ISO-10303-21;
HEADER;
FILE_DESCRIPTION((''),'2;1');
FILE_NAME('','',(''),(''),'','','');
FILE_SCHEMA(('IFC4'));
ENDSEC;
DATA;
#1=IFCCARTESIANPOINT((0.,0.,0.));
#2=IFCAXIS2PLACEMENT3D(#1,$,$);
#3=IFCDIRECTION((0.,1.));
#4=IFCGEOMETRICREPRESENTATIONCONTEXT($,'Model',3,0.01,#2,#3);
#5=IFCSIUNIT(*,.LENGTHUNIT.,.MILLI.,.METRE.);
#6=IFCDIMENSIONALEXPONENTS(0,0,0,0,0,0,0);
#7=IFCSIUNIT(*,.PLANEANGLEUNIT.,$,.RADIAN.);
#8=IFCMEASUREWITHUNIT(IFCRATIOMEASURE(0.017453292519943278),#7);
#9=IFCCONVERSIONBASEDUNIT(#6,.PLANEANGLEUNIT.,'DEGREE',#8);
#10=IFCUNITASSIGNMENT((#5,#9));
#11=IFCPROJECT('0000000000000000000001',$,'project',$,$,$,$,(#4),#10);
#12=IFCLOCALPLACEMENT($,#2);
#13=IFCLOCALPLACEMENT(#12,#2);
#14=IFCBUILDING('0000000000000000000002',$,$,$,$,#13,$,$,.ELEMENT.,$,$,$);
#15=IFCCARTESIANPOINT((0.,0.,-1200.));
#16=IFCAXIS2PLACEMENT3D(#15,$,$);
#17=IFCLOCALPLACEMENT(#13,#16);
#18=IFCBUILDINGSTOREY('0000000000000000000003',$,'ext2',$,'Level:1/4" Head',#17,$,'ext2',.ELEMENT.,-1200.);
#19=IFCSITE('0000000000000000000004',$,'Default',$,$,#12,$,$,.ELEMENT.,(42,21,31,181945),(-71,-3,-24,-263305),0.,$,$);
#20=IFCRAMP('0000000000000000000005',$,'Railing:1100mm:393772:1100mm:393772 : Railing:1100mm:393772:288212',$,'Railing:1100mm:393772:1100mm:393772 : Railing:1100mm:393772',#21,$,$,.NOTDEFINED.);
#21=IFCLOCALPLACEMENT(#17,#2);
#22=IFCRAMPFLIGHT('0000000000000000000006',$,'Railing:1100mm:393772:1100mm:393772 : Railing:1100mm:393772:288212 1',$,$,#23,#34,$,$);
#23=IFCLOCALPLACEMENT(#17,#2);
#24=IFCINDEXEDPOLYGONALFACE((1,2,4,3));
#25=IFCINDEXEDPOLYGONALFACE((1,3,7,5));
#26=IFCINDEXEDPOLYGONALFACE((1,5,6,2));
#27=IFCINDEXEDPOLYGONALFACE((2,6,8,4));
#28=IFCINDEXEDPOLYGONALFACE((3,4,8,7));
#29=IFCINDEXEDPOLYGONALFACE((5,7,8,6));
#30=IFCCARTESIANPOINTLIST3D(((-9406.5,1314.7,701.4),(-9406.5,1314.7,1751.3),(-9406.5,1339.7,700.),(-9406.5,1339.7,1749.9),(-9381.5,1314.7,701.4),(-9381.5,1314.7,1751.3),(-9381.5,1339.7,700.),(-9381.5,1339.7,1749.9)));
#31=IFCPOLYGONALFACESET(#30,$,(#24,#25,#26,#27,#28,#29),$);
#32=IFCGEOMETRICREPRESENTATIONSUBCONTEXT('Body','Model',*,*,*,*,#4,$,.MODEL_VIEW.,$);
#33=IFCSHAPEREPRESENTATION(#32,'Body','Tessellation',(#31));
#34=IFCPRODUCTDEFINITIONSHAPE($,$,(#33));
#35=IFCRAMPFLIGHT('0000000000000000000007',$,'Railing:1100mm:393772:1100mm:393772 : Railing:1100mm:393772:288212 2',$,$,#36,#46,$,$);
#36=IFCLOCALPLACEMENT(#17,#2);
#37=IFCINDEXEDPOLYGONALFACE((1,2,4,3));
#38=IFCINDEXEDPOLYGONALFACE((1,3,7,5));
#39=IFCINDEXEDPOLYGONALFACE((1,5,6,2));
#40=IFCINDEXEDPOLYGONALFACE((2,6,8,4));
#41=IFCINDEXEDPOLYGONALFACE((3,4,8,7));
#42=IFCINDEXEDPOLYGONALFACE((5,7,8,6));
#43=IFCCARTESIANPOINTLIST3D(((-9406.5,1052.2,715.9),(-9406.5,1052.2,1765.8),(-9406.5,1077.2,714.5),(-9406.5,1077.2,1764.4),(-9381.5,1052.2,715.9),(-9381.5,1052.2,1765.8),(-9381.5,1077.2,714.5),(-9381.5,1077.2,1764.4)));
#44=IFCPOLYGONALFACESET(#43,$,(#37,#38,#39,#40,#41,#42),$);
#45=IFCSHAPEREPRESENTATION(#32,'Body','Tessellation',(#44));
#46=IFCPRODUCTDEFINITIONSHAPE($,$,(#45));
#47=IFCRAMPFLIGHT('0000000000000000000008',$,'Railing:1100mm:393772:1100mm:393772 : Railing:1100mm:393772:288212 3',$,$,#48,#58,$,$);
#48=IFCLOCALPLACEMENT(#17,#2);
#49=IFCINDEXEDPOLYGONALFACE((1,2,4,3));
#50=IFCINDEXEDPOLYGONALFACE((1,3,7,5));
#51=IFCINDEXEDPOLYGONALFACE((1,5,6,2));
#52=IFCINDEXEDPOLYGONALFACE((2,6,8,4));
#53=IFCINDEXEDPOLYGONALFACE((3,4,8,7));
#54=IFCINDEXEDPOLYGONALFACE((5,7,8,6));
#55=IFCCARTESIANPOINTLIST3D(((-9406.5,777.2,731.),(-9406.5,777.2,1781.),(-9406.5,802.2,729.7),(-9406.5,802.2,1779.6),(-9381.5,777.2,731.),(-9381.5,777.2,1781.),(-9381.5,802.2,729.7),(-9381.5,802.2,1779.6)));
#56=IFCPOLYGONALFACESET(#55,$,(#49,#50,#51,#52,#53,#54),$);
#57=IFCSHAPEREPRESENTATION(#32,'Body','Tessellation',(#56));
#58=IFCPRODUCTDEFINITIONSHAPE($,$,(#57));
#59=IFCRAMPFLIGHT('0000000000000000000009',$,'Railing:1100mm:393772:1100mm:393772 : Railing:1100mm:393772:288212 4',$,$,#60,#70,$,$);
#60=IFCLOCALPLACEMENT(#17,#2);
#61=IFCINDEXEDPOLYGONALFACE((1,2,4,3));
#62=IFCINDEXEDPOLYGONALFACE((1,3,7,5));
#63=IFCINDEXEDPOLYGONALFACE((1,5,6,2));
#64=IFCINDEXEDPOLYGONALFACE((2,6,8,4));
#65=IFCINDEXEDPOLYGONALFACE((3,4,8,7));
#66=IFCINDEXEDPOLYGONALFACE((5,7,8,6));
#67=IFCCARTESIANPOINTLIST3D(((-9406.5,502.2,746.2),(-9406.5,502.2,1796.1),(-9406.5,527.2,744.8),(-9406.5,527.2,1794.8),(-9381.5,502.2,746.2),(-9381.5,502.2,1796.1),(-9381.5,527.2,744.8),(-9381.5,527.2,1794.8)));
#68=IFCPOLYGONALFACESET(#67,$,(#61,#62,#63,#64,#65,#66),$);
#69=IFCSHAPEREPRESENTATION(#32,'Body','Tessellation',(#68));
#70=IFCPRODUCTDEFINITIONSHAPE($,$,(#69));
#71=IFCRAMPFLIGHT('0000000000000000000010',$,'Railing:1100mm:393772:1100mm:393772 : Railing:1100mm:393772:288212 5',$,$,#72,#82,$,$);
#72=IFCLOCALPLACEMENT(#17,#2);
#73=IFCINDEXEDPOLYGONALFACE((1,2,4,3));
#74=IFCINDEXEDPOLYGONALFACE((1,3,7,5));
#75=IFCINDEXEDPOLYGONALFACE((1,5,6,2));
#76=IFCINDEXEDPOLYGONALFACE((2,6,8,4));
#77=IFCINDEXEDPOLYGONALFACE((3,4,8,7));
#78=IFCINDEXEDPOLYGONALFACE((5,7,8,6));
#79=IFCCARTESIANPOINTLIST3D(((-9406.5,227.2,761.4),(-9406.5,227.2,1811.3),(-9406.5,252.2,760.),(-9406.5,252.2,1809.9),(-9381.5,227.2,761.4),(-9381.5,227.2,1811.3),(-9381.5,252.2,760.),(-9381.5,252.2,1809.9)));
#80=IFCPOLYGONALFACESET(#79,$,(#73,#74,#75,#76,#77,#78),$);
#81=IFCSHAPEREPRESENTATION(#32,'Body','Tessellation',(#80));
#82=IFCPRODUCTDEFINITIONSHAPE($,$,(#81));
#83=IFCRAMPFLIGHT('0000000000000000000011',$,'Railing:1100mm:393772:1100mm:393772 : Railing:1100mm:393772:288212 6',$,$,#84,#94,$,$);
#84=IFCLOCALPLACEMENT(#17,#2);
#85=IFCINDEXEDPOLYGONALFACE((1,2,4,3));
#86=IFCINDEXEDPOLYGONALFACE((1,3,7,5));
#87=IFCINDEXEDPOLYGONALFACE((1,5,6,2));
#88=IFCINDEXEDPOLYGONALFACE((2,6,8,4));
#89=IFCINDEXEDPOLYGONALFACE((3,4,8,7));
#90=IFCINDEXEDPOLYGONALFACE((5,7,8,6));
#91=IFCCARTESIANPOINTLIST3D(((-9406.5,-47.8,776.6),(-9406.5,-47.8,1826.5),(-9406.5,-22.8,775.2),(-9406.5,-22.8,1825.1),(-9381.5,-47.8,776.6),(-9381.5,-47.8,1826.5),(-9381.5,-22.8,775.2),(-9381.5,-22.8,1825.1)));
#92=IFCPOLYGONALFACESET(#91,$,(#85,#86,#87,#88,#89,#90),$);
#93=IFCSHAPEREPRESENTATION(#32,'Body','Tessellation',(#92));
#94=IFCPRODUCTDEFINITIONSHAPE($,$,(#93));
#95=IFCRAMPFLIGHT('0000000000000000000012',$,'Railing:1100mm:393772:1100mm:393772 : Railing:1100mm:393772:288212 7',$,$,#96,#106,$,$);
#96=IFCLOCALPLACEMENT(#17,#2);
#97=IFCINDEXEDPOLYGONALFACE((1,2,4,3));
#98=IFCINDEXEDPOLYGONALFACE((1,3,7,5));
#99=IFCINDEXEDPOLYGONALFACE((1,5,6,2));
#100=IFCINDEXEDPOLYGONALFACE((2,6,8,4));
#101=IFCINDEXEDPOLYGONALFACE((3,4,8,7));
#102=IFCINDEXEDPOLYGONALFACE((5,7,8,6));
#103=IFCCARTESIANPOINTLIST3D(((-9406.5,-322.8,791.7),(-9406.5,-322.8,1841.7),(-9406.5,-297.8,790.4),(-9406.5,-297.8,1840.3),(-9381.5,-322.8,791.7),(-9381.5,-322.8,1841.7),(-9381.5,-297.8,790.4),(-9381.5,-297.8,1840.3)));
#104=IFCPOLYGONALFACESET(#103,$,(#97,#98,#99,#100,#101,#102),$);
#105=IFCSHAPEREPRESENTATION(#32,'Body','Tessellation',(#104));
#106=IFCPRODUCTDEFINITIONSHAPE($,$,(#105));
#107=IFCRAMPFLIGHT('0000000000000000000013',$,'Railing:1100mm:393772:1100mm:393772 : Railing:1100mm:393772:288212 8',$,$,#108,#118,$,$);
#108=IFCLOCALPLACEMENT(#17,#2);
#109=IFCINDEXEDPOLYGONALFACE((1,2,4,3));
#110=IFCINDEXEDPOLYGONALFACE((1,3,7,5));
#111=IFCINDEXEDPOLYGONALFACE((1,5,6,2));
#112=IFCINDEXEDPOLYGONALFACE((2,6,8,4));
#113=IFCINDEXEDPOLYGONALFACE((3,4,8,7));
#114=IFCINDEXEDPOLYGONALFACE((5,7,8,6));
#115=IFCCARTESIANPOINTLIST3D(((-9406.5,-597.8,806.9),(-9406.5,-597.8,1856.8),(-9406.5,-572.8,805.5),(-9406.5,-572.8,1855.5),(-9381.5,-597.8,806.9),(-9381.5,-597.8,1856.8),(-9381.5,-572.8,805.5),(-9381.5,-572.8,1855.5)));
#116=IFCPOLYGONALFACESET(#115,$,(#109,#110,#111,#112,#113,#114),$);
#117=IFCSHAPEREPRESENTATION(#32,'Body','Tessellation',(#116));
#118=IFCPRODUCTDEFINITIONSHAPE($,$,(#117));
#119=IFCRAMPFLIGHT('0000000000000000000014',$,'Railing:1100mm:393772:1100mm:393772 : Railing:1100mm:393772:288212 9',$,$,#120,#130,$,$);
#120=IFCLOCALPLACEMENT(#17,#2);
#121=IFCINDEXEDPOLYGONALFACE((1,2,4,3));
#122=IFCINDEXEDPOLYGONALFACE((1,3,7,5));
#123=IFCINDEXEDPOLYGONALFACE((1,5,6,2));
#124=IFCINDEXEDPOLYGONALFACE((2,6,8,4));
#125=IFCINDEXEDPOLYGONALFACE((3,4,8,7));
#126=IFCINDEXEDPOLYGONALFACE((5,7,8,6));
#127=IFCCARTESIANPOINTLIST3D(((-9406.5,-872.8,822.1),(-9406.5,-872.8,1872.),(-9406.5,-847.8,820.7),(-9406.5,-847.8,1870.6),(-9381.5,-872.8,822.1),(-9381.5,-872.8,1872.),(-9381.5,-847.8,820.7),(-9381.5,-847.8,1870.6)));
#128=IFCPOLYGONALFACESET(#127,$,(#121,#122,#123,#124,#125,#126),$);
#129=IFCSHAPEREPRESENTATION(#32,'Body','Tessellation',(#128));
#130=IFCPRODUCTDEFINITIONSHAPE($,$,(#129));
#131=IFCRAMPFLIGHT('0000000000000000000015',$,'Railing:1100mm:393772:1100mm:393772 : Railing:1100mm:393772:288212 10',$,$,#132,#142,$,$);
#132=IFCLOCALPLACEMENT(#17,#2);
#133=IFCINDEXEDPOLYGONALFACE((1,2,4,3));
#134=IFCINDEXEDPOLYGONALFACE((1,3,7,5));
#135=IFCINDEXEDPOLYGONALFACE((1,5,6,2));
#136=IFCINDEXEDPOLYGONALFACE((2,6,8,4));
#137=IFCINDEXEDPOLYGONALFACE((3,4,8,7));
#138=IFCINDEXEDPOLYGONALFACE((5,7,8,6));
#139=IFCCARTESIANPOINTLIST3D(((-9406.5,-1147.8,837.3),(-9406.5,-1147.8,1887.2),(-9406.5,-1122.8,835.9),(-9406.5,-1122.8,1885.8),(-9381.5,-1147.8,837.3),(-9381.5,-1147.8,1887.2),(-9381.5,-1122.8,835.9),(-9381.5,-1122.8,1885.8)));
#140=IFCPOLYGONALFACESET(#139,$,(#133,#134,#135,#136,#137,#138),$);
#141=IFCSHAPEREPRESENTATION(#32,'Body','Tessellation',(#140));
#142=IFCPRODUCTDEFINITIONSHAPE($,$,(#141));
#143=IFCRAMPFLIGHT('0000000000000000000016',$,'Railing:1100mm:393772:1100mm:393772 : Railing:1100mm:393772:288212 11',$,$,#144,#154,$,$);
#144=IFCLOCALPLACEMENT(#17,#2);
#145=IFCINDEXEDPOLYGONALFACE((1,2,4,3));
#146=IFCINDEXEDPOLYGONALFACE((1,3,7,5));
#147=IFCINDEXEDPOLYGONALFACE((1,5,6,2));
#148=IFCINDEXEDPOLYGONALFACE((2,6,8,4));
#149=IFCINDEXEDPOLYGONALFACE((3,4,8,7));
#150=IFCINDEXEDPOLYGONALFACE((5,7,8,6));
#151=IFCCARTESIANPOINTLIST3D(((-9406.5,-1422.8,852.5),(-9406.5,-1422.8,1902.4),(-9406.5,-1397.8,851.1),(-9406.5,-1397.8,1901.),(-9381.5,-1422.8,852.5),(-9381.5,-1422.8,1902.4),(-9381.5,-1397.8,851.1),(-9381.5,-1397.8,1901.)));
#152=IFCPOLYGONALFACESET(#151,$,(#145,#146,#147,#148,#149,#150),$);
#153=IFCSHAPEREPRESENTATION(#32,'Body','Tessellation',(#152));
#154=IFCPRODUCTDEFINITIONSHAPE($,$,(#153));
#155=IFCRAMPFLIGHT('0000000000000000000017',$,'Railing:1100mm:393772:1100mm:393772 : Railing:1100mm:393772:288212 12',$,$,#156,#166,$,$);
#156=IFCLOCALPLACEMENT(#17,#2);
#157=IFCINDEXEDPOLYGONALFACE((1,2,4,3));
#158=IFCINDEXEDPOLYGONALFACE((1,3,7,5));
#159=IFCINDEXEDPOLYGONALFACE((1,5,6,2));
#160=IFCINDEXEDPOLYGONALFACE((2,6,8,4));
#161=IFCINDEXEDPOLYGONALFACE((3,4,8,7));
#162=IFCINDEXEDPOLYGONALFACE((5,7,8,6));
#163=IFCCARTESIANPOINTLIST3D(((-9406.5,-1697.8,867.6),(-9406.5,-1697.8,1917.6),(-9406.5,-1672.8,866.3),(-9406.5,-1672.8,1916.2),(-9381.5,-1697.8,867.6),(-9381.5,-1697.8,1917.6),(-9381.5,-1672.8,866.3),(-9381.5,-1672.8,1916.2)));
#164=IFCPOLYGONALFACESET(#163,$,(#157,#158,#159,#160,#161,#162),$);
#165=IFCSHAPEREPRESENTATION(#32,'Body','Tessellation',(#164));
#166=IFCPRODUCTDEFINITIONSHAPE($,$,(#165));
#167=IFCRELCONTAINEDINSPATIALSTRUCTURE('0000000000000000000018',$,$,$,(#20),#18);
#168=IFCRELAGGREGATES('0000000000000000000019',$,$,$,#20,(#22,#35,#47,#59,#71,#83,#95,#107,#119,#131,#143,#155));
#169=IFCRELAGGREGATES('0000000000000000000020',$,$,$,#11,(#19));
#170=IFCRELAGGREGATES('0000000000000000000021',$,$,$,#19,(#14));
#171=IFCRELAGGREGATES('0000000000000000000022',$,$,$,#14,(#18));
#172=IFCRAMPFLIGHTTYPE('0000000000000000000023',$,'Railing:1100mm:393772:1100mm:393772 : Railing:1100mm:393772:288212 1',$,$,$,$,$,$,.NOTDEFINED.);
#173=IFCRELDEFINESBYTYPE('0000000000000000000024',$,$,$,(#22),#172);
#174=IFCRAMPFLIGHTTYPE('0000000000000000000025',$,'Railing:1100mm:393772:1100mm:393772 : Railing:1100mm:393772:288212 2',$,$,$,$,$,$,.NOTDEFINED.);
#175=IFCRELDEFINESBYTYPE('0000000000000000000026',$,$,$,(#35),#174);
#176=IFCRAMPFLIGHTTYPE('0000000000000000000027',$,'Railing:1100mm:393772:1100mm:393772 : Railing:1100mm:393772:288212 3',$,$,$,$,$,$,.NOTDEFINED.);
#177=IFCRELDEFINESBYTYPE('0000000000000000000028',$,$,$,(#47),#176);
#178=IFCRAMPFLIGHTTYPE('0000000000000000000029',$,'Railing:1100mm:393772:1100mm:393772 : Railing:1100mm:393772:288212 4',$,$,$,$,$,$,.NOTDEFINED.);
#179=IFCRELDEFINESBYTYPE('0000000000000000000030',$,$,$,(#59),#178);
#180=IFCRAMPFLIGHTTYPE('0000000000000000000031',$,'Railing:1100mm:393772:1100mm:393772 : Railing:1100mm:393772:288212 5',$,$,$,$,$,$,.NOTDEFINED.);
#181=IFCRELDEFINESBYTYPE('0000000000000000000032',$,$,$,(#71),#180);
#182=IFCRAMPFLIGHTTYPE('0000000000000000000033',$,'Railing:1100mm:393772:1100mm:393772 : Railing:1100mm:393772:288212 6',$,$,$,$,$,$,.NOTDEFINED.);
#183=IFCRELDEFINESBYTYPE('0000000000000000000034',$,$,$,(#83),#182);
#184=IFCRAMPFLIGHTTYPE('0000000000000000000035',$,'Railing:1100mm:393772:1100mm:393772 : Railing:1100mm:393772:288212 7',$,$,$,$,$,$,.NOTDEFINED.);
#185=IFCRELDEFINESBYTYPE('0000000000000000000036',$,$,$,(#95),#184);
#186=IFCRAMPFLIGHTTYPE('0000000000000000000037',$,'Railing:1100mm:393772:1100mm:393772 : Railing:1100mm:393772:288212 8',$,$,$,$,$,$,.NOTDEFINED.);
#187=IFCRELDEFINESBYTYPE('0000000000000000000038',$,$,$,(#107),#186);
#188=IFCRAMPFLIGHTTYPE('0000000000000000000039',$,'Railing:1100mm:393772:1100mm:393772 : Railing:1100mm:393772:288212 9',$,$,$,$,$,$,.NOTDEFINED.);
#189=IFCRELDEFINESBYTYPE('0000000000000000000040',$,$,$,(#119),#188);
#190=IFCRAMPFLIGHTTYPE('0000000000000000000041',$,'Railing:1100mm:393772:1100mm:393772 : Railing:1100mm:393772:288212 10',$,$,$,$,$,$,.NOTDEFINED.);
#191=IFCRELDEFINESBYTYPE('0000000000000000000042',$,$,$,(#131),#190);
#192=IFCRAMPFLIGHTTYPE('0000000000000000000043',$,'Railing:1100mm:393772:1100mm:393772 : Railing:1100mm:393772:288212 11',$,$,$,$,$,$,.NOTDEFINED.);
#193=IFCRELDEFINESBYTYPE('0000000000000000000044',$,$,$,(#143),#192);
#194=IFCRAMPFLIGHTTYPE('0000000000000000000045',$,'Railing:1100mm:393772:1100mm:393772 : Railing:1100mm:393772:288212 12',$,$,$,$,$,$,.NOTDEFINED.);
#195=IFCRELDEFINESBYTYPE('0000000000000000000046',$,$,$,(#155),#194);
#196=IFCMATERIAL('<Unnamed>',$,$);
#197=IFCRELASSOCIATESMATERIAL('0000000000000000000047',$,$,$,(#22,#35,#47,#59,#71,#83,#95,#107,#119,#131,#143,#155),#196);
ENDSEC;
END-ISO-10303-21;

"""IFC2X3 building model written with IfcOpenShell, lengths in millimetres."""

from ifc_helpers import new_model, entity, si_unit, converted_unit, direction, frame, origin, place, context, subcontext, project, spatial, polyline, outline, extrude, material, type_object, element, aggregate, save


model = new_model("IFC2X3")

# Units and contexts
model_context = context("Model", 3, precision=0.01, world=origin(), true_north=direction((0.0, 1.0)))
body_context = subcontext(model_context, "Body", "Model", "MODEL_VIEW")
ifc_project = project(units=[si_unit("LENGTHUNIT", "METRE", prefix="MILLI"), converted_unit("PLANEANGLEUNIT", "DEGREE", entity("IfcRatioMeasure", 0.017453292519943278), si_unit("PLANEANGLEUNIT", "RADIAN"), dimensions=[0, 0, 0, 0, 0, 0, 0])], contexts=[model_context])

# Site, building, storey
site_placement = place(None, origin())
site = spatial("IfcSite", under=ifc_project, at=site_placement, Name="Default", CompositionType="ELEMENT", RefLatitude=(42, 21, 31, 181945), RefLongitude=(-71, -3, -24, -263305), RefElevation=0.0)
building_placement = place(site_placement, origin())
building = spatial("IfcBuilding", under=site, at=building_placement, CompositionType="ELEMENT")
storey_placement = place(building_placement, frame((0.0, 0.0, -1200.0)))
storey = spatial("IfcBuildingStorey", under=building, at=storey_placement, Name="ext2", ObjectType="Level:1/4\" Head", LongName="ext2", CompositionType="ELEMENT", Elevation=-1200.0)

# Ramp, ramp flights
ramp_placement = place(storey_placement, origin())
ramp = element("IfcRamp", 1, at=ramp_placement, inside=storey, Name="Railing:1100mm:393772:1100mm:393772 : Railing:1100mm:393772:288212", ObjectType="Railing:1100mm:393772:1100mm:393772 : Railing:1100mm:393772", ShapeType="NOTDEFINED")
ifc_material = material(Name="<Unnamed>")
ramp_flight_type_1 = type_object("IfcRampFlightType", Name="Railing:1100mm:393772:1100mm:393772 : Railing:1100mm:393772:288212 1", PredefinedType="NOTDEFINED")
ramp_flight_1_placement = place(ramp_placement, origin())
ramp_flight_1 = element("IfcRampFlight", 2, at=ramp_flight_1_placement, type_object=ramp_flight_type_1, material=ifc_material, Name="Railing:1100mm:393772:1100mm:393772 : Railing:1100mm:393772:288212 1", context=body_context, shape_type="SweptSolid", body=[
    extrude(outline(polyline([(-525.7, -12.5), (524.3, -12.5), (525.7, 12.5), (-524.3, 12.5), (-525.7, -12.5)])), frame((-9406.5, 1327.2, 1225.7), z_axis=(1.0, 0.0, 0.0), x_axis=(0.0, 0.0, -1.0)), (0.0, 0.0, 1.0), 25.0),
])
ramp_flight_type_2 = type_object("IfcRampFlightType", Name="Railing:1100mm:393772:1100mm:393772 : Railing:1100mm:393772:288212 2", PredefinedType="NOTDEFINED")
ramp_flight_2_placement = place(ramp_placement, origin())
ramp_flight_2 = element("IfcRampFlight", 3, at=ramp_flight_2_placement, type_object=ramp_flight_type_2, material=ifc_material, Name="Railing:1100mm:393772:1100mm:393772 : Railing:1100mm:393772:288212 2", context=body_context, shape_type="SweptSolid", body=[
    extrude(outline(polyline([(-525.7, -12.5), (524.3, -12.5), (525.7, 12.5), (-524.3, 12.5), (-525.7, -12.5)])), frame((-9406.5, 1064.7, 1240.1), z_axis=(1.0, 0.0, 0.0), x_axis=(0.0, 0.0, -1.0)), (0.0, 0.0, 1.0), 25.0),
])
ramp_flight_type_3 = type_object("IfcRampFlightType", Name="Railing:1100mm:393772:1100mm:393772 : Railing:1100mm:393772:288212 3", PredefinedType="NOTDEFINED")
ramp_flight_3_placement = place(ramp_placement, origin())
ramp_flight_3 = element("IfcRampFlight", 4, at=ramp_flight_3_placement, type_object=ramp_flight_type_3, material=ifc_material, Name="Railing:1100mm:393772:1100mm:393772 : Railing:1100mm:393772:288212 3", context=body_context, shape_type="SweptSolid", body=[
    extrude(outline(polyline([(-525.7, -12.5), (524.3, -12.5), (525.7, 12.5), (-524.3, 12.5), (-525.7, -12.5)])), frame((-9406.5, 789.7, 1255.3), z_axis=(1.0, 0.0, 0.0), x_axis=(0.0, 0.0, -1.0)), (0.0, 0.0, 1.0), 25.0),
])
ramp_flight_type_4 = type_object("IfcRampFlightType", Name="Railing:1100mm:393772:1100mm:393772 : Railing:1100mm:393772:288212 4", PredefinedType="NOTDEFINED")
ramp_flight_4_placement = place(ramp_placement, origin())
ramp_flight_4 = element("IfcRampFlight", 5, at=ramp_flight_4_placement, type_object=ramp_flight_type_4, material=ifc_material, Name="Railing:1100mm:393772:1100mm:393772 : Railing:1100mm:393772:288212 4", context=body_context, shape_type="SweptSolid", body=[
    extrude(outline(polyline([(-525.7, -12.5), (524.3, -12.5), (525.7, 12.5), (-524.3, 12.5), (-525.7, -12.5)])), frame((-9406.5, 514.7, 1270.5), z_axis=(1.0, 0.0, 0.0), x_axis=(0.0, 0.0, -1.0)), (0.0, 0.0, 1.0), 25.0),
])
ramp_flight_type_5 = type_object("IfcRampFlightType", Name="Railing:1100mm:393772:1100mm:393772 : Railing:1100mm:393772:288212 5", PredefinedType="NOTDEFINED")
ramp_flight_5_placement = place(ramp_placement, origin())
ramp_flight_5 = element("IfcRampFlight", 6, at=ramp_flight_5_placement, type_object=ramp_flight_type_5, material=ifc_material, Name="Railing:1100mm:393772:1100mm:393772 : Railing:1100mm:393772:288212 5", context=body_context, shape_type="SweptSolid", body=[
    extrude(outline(polyline([(-525.7, -12.5), (524.3, -12.5), (525.7, 12.5), (-524.3, 12.5), (-525.7, -12.5)])), frame((-9406.5, 239.7, 1285.7), z_axis=(1.0, 0.0, 0.0), x_axis=(0.0, 0.0, -1.0)), (0.0, 0.0, 1.0), 25.0),
])
ramp_flight_type_6 = type_object("IfcRampFlightType", Name="Railing:1100mm:393772:1100mm:393772 : Railing:1100mm:393772:288212 6", PredefinedType="NOTDEFINED")
ramp_flight_6_placement = place(ramp_placement, origin())
ramp_flight_6 = element("IfcRampFlight", 7, at=ramp_flight_6_placement, type_object=ramp_flight_type_6, material=ifc_material, Name="Railing:1100mm:393772:1100mm:393772 : Railing:1100mm:393772:288212 6", context=body_context, shape_type="SweptSolid", body=[
    extrude(outline(polyline([(-525.7, -12.5), (524.3, -12.5), (525.7, 12.5), (-524.3, 12.5), (-525.7, -12.5)])), frame((-9406.5, -35.3, 1300.8), z_axis=(1.0, 0.0, 0.0), x_axis=(0.0, 0.0, -1.0)), (0.0, 0.0, 1.0), 25.0),
])
ramp_flight_type_7 = type_object("IfcRampFlightType", Name="Railing:1100mm:393772:1100mm:393772 : Railing:1100mm:393772:288212 7", PredefinedType="NOTDEFINED")
ramp_flight_7_placement = place(ramp_placement, origin())
ramp_flight_7 = element("IfcRampFlight", 8, at=ramp_flight_7_placement, type_object=ramp_flight_type_7, material=ifc_material, Name="Railing:1100mm:393772:1100mm:393772 : Railing:1100mm:393772:288212 7", context=body_context, shape_type="SweptSolid", body=[
    extrude(outline(polyline([(-525.7, -12.5), (524.3, -12.5), (525.7, 12.5), (-524.3, 12.5), (-525.7, -12.5)])), frame((-9406.5, -310.3, 1316.0), z_axis=(1.0, 0.0, 0.0), x_axis=(0.0, 0.0, -1.0)), (0.0, 0.0, 1.0), 25.0),
])
ramp_flight_type_8 = type_object("IfcRampFlightType", Name="Railing:1100mm:393772:1100mm:393772 : Railing:1100mm:393772:288212 8", PredefinedType="NOTDEFINED")
ramp_flight_8_placement = place(ramp_placement, origin())
ramp_flight_8 = element("IfcRampFlight", 9, at=ramp_flight_8_placement, type_object=ramp_flight_type_8, material=ifc_material, Name="Railing:1100mm:393772:1100mm:393772 : Railing:1100mm:393772:288212 8", context=body_context, shape_type="SweptSolid", body=[
    extrude(outline(polyline([(-525.7, -12.5), (524.3, -12.5), (525.7, 12.5), (-524.3, 12.5), (-525.7, -12.5)])), frame((-9406.5, -585.3, 1331.2), z_axis=(1.0, 0.0, 0.0), x_axis=(0.0, 0.0, -1.0)), (0.0, 0.0, 1.0), 25.0),
])
ramp_flight_type_9 = type_object("IfcRampFlightType", Name="Railing:1100mm:393772:1100mm:393772 : Railing:1100mm:393772:288212 9", PredefinedType="NOTDEFINED")
ramp_flight_9_placement = place(ramp_placement, origin())
ramp_flight_9 = element("IfcRampFlight", 10, at=ramp_flight_9_placement, type_object=ramp_flight_type_9, material=ifc_material, Name="Railing:1100mm:393772:1100mm:393772 : Railing:1100mm:393772:288212 9", context=body_context, shape_type="SweptSolid", body=[
    extrude(outline(polyline([(-525.7, -12.5), (524.3, -12.5), (525.7, 12.5), (-524.3, 12.5), (-525.7, -12.5)])), frame((-9406.5, -860.3, 1346.4), z_axis=(1.0, 0.0, 0.0), x_axis=(0.0, 0.0, -1.0)), (0.0, 0.0, 1.0), 25.0),
])
ramp_flight_type_10 = type_object("IfcRampFlightType", Name="Railing:1100mm:393772:1100mm:393772 : Railing:1100mm:393772:288212 10", PredefinedType="NOTDEFINED")
ramp_flight_10_placement = place(ramp_placement, origin())
ramp_flight_10 = element("IfcRampFlight", 11, at=ramp_flight_10_placement, type_object=ramp_flight_type_10, material=ifc_material, Name="Railing:1100mm:393772:1100mm:393772 : Railing:1100mm:393772:288212 10", context=body_context, shape_type="SweptSolid", body=[
    extrude(outline(polyline([(-525.7, -12.5), (524.3, -12.5), (525.7, 12.5), (-524.3, 12.5), (-525.7, -12.5)])), frame((-9406.5, -1135.3, 1361.5), z_axis=(1.0, 0.0, 0.0), x_axis=(0.0, 0.0, -1.0)), (0.0, 0.0, 1.0), 25.0),
])
ramp_flight_type_11 = type_object("IfcRampFlightType", Name="Railing:1100mm:393772:1100mm:393772 : Railing:1100mm:393772:288212 11", PredefinedType="NOTDEFINED")
ramp_flight_11_placement = place(ramp_placement, origin())
ramp_flight_11 = element("IfcRampFlight", 12, at=ramp_flight_11_placement, type_object=ramp_flight_type_11, material=ifc_material, Name="Railing:1100mm:393772:1100mm:393772 : Railing:1100mm:393772:288212 11", context=body_context, shape_type="SweptSolid", body=[
    extrude(outline(polyline([(-525.7, -12.5), (524.3, -12.5), (525.7, 12.5), (-524.3, 12.5), (-525.7, -12.5)])), frame((-9406.5, -1410.3, 1376.7), z_axis=(1.0, 0.0, 0.0), x_axis=(0.0, 0.0, -1.0)), (0.0, 0.0, 1.0), 25.0),
])
ramp_flight_type_12 = type_object("IfcRampFlightType", Name="Railing:1100mm:393772:1100mm:393772 : Railing:1100mm:393772:288212 12", PredefinedType="NOTDEFINED")
ramp_flight_12_placement = place(ramp_placement, origin())
ramp_flight_12 = element("IfcRampFlight", 13, at=ramp_flight_12_placement, type_object=ramp_flight_type_12, material=ifc_material, Name="Railing:1100mm:393772:1100mm:393772 : Railing:1100mm:393772:288212 12", context=body_context, shape_type="SweptSolid", body=[
    extrude(outline(polyline([(-525.7, -12.5), (524.3, -12.5), (525.7, 12.5), (-524.3, 12.5), (-525.7, -12.5)])), frame((-9406.5, -1685.3, 1391.9), z_axis=(1.0, 0.0, 0.0), x_axis=(0.0, 0.0, -1.0)), (0.0, 0.0, 1.0), 25.0),
])
aggregate(ramp, [ramp_flight_1, ramp_flight_2, ramp_flight_3, ramp_flight_4, ramp_flight_5, ramp_flight_6, ramp_flight_7, ramp_flight_8, ramp_flight_9, ramp_flight_10, ramp_flight_11, ramp_flight_12])

save(model, "model.ifc")
